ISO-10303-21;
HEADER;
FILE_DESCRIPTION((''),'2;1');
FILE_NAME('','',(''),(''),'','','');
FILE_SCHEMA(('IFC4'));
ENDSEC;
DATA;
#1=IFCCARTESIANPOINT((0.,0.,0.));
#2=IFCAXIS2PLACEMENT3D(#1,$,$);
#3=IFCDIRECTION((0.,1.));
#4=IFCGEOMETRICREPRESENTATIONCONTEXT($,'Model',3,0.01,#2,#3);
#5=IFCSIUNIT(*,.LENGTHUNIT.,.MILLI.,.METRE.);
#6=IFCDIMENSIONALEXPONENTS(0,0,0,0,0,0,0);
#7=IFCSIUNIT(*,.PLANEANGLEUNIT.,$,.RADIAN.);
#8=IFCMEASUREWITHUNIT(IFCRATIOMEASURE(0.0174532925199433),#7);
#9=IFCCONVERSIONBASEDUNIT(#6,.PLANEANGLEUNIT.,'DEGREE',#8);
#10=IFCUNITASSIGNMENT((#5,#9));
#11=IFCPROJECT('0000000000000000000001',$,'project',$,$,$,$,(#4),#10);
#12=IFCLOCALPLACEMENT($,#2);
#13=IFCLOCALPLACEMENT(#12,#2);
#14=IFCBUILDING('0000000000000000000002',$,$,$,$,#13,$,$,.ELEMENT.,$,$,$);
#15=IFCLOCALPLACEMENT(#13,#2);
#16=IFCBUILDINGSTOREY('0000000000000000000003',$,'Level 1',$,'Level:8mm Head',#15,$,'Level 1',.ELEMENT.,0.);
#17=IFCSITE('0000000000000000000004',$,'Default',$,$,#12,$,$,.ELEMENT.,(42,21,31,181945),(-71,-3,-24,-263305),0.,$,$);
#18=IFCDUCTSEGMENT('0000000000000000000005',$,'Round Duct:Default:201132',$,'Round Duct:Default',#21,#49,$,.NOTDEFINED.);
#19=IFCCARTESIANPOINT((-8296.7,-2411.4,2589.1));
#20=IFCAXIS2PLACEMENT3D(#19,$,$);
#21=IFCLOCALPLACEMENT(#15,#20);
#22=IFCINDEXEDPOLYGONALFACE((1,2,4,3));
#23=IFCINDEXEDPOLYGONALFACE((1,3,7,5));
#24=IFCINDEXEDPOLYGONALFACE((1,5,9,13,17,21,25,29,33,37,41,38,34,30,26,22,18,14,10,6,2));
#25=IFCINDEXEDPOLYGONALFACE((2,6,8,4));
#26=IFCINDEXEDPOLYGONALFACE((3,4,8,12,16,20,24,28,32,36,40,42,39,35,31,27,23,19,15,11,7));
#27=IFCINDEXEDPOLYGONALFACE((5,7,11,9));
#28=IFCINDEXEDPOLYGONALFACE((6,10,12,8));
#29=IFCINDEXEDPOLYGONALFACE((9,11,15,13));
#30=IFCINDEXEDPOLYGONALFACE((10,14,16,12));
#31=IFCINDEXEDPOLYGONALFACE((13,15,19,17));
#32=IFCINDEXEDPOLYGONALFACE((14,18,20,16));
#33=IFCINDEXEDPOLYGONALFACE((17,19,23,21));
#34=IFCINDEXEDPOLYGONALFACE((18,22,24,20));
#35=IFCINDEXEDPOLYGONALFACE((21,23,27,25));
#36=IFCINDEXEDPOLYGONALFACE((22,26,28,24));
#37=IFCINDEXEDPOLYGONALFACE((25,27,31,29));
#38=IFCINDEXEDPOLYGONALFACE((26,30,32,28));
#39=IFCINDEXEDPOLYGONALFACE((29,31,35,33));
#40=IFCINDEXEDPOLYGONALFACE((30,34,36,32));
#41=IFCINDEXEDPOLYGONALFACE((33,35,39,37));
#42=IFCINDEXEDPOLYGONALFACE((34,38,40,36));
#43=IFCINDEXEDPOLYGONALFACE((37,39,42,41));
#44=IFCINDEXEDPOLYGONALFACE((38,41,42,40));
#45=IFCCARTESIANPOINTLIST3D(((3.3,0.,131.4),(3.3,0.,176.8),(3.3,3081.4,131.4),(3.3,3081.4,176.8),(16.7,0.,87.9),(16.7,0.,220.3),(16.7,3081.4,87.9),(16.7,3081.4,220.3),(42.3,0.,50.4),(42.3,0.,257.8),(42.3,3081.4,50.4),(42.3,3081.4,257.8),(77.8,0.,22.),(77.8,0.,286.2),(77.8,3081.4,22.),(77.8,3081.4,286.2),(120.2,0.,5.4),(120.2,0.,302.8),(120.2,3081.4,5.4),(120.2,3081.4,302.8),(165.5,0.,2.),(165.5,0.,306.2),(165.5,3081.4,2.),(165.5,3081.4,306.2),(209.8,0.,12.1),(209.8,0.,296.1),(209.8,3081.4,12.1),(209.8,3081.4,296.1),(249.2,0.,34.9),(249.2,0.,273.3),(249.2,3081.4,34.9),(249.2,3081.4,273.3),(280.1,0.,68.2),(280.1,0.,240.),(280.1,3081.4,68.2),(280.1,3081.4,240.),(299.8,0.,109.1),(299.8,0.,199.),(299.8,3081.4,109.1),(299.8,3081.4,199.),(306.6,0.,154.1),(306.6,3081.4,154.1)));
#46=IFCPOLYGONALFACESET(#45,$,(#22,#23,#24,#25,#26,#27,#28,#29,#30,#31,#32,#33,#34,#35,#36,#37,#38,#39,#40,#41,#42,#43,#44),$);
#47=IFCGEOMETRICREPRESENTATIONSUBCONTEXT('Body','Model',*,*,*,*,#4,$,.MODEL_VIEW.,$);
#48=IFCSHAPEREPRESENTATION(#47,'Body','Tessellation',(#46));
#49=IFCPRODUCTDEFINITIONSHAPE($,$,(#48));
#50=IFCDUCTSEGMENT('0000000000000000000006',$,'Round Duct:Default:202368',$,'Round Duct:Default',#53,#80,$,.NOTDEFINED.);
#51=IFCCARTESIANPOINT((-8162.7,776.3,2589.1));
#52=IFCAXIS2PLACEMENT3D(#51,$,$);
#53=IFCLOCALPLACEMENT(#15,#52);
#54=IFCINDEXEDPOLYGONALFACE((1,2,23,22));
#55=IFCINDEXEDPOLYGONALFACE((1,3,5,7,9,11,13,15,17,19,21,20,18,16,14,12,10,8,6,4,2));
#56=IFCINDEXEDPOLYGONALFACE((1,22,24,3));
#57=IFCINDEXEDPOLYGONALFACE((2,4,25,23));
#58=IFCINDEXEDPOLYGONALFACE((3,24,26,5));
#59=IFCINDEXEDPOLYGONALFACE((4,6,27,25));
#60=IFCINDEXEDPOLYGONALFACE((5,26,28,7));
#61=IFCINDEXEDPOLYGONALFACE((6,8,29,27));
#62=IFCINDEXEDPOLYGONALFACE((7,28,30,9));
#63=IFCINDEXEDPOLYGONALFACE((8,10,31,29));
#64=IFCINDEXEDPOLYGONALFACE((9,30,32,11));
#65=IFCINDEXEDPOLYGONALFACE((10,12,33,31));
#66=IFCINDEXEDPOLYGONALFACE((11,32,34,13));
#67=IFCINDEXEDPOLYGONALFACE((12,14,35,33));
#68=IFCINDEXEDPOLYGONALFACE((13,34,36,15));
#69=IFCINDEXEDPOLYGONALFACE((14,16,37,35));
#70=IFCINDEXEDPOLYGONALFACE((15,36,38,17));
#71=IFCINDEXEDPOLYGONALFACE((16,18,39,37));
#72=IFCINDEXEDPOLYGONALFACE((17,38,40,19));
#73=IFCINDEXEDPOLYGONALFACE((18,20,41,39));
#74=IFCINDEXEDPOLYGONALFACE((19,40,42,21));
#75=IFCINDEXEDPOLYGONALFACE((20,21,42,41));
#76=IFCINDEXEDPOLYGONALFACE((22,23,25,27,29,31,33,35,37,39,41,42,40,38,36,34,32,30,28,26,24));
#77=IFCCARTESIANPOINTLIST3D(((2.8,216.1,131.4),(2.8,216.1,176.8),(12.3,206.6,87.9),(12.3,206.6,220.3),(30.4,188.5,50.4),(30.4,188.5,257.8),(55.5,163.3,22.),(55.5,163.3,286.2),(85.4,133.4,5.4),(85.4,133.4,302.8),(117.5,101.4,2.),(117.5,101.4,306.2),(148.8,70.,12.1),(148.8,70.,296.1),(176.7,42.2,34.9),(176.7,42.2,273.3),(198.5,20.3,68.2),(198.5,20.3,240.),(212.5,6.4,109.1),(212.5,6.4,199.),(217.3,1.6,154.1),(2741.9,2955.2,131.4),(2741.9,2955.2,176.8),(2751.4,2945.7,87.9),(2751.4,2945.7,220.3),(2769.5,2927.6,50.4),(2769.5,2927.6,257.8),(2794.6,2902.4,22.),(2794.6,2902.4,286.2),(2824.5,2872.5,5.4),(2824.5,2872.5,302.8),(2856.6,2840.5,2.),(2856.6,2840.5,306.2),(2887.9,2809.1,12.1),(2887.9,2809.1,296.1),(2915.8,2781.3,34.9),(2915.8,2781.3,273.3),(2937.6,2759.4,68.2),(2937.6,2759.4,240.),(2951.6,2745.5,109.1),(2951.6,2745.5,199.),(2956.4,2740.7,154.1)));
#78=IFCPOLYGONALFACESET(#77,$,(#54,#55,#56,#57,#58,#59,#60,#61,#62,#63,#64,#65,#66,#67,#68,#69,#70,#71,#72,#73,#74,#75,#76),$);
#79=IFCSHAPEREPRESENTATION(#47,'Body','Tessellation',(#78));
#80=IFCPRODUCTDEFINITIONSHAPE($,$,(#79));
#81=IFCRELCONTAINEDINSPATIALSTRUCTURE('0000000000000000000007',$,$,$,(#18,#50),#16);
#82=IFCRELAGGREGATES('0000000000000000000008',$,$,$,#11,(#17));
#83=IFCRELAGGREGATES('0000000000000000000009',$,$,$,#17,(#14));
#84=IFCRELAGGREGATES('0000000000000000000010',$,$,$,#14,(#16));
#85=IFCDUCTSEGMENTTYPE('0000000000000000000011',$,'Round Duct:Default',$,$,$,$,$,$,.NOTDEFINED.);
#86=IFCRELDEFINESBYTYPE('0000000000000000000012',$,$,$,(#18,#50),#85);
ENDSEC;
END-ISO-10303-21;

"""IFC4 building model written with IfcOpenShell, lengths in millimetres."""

from ifc_helpers import new_model, entity, si_unit, converted_unit, direction, frame, frame_2d, origin, place, context, subcontext, project, spatial, circle, extrude, type_object, element, save


model = new_model("IFC4")

# Units and contexts
model_context = context("Model", 3, precision=0.01, world=origin(), true_north=direction((0.0, 1.0)))
body_context = subcontext(model_context, "Body", "Model", "MODEL_VIEW")
ifc_project = project(units=[si_unit("LENGTHUNIT", "METRE", prefix="MILLI"), converted_unit("PLANEANGLEUNIT", "DEGREE", entity("IfcRatioMeasure", 0.0174532925199433), si_unit("PLANEANGLEUNIT", "RADIAN"), dimensions=[0, 0, 0, 0, 0, 0, 0])], contexts=[model_context])

# Site, building, storey
site_placement = place(None, origin())
site = spatial("IfcSite", under=ifc_project, at=site_placement, Name="Default", CompositionType="ELEMENT", RefLatitude=(42, 21, 31, 181945), RefLongitude=(-71, -3, -24, -263305), RefElevation=0.0)
building_placement = place(site_placement, origin())
building = spatial("IfcBuilding", under=site, at=building_placement, CompositionType="ELEMENT")
storey_placement = place(building_placement, origin())
storey = spatial("IfcBuildingStorey", under=building, at=storey_placement, Name="Level 1", ObjectType="Level:8mm Head", LongName="Level 1", CompositionType="ELEMENT", Elevation=0.0)

# Duct segments
duct_segment_type = type_object("IfcDuctSegmentType", Name="Round Duct:Default", PredefinedType="NOTDEFINED")
duct_segment_1_placement = place(storey_placement, frame((-8296.7, -2411.4, 2589.1)))
element("IfcDuctSegment", 1, at=duct_segment_1_placement, inside=storey, type_object=duct_segment_type, Name="Round Duct:Default:201132", ObjectType="Round Duct:Default", PredefinedType="NOTDEFINED", context=body_context, shape_type="SweptSolid", body=[
    extrude(circle(Radius=152.5, at=frame_2d((0.0, 0.0), x_axis=(1.0, 0.0))), frame((154.1, 0.0, 154.1), z_axis=(0.0, 1.0, 0.0), x_axis=(1.0, 0.0, 0.0)), (0.0, 0.0, 1.0), 3081.4),
])
duct_segment_2_placement = place(storey_placement, frame((-8162.7, 776.3, 2589.1)))
element("IfcDuctSegment", 2, at=duct_segment_2_placement, inside=storey, type_object=duct_segment_type, Name="Round Duct:Default:202368", ObjectType="Round Duct:Default", PredefinedType="NOTDEFINED", context=body_context, shape_type="SweptSolid", body=[
    extrude(circle(Radius=152.5, at=frame_2d((0.0, 0.0), x_axis=(1.0, 0.0))), frame((109.4, 109.4, 154.1), z_axis=(0.707107, 0.707107, 0.0), x_axis=(0.707107, -0.707107, 0.0)), (0.0, 0.0, 1.0), 3873.7),
])

save(model, "model.ifc")
